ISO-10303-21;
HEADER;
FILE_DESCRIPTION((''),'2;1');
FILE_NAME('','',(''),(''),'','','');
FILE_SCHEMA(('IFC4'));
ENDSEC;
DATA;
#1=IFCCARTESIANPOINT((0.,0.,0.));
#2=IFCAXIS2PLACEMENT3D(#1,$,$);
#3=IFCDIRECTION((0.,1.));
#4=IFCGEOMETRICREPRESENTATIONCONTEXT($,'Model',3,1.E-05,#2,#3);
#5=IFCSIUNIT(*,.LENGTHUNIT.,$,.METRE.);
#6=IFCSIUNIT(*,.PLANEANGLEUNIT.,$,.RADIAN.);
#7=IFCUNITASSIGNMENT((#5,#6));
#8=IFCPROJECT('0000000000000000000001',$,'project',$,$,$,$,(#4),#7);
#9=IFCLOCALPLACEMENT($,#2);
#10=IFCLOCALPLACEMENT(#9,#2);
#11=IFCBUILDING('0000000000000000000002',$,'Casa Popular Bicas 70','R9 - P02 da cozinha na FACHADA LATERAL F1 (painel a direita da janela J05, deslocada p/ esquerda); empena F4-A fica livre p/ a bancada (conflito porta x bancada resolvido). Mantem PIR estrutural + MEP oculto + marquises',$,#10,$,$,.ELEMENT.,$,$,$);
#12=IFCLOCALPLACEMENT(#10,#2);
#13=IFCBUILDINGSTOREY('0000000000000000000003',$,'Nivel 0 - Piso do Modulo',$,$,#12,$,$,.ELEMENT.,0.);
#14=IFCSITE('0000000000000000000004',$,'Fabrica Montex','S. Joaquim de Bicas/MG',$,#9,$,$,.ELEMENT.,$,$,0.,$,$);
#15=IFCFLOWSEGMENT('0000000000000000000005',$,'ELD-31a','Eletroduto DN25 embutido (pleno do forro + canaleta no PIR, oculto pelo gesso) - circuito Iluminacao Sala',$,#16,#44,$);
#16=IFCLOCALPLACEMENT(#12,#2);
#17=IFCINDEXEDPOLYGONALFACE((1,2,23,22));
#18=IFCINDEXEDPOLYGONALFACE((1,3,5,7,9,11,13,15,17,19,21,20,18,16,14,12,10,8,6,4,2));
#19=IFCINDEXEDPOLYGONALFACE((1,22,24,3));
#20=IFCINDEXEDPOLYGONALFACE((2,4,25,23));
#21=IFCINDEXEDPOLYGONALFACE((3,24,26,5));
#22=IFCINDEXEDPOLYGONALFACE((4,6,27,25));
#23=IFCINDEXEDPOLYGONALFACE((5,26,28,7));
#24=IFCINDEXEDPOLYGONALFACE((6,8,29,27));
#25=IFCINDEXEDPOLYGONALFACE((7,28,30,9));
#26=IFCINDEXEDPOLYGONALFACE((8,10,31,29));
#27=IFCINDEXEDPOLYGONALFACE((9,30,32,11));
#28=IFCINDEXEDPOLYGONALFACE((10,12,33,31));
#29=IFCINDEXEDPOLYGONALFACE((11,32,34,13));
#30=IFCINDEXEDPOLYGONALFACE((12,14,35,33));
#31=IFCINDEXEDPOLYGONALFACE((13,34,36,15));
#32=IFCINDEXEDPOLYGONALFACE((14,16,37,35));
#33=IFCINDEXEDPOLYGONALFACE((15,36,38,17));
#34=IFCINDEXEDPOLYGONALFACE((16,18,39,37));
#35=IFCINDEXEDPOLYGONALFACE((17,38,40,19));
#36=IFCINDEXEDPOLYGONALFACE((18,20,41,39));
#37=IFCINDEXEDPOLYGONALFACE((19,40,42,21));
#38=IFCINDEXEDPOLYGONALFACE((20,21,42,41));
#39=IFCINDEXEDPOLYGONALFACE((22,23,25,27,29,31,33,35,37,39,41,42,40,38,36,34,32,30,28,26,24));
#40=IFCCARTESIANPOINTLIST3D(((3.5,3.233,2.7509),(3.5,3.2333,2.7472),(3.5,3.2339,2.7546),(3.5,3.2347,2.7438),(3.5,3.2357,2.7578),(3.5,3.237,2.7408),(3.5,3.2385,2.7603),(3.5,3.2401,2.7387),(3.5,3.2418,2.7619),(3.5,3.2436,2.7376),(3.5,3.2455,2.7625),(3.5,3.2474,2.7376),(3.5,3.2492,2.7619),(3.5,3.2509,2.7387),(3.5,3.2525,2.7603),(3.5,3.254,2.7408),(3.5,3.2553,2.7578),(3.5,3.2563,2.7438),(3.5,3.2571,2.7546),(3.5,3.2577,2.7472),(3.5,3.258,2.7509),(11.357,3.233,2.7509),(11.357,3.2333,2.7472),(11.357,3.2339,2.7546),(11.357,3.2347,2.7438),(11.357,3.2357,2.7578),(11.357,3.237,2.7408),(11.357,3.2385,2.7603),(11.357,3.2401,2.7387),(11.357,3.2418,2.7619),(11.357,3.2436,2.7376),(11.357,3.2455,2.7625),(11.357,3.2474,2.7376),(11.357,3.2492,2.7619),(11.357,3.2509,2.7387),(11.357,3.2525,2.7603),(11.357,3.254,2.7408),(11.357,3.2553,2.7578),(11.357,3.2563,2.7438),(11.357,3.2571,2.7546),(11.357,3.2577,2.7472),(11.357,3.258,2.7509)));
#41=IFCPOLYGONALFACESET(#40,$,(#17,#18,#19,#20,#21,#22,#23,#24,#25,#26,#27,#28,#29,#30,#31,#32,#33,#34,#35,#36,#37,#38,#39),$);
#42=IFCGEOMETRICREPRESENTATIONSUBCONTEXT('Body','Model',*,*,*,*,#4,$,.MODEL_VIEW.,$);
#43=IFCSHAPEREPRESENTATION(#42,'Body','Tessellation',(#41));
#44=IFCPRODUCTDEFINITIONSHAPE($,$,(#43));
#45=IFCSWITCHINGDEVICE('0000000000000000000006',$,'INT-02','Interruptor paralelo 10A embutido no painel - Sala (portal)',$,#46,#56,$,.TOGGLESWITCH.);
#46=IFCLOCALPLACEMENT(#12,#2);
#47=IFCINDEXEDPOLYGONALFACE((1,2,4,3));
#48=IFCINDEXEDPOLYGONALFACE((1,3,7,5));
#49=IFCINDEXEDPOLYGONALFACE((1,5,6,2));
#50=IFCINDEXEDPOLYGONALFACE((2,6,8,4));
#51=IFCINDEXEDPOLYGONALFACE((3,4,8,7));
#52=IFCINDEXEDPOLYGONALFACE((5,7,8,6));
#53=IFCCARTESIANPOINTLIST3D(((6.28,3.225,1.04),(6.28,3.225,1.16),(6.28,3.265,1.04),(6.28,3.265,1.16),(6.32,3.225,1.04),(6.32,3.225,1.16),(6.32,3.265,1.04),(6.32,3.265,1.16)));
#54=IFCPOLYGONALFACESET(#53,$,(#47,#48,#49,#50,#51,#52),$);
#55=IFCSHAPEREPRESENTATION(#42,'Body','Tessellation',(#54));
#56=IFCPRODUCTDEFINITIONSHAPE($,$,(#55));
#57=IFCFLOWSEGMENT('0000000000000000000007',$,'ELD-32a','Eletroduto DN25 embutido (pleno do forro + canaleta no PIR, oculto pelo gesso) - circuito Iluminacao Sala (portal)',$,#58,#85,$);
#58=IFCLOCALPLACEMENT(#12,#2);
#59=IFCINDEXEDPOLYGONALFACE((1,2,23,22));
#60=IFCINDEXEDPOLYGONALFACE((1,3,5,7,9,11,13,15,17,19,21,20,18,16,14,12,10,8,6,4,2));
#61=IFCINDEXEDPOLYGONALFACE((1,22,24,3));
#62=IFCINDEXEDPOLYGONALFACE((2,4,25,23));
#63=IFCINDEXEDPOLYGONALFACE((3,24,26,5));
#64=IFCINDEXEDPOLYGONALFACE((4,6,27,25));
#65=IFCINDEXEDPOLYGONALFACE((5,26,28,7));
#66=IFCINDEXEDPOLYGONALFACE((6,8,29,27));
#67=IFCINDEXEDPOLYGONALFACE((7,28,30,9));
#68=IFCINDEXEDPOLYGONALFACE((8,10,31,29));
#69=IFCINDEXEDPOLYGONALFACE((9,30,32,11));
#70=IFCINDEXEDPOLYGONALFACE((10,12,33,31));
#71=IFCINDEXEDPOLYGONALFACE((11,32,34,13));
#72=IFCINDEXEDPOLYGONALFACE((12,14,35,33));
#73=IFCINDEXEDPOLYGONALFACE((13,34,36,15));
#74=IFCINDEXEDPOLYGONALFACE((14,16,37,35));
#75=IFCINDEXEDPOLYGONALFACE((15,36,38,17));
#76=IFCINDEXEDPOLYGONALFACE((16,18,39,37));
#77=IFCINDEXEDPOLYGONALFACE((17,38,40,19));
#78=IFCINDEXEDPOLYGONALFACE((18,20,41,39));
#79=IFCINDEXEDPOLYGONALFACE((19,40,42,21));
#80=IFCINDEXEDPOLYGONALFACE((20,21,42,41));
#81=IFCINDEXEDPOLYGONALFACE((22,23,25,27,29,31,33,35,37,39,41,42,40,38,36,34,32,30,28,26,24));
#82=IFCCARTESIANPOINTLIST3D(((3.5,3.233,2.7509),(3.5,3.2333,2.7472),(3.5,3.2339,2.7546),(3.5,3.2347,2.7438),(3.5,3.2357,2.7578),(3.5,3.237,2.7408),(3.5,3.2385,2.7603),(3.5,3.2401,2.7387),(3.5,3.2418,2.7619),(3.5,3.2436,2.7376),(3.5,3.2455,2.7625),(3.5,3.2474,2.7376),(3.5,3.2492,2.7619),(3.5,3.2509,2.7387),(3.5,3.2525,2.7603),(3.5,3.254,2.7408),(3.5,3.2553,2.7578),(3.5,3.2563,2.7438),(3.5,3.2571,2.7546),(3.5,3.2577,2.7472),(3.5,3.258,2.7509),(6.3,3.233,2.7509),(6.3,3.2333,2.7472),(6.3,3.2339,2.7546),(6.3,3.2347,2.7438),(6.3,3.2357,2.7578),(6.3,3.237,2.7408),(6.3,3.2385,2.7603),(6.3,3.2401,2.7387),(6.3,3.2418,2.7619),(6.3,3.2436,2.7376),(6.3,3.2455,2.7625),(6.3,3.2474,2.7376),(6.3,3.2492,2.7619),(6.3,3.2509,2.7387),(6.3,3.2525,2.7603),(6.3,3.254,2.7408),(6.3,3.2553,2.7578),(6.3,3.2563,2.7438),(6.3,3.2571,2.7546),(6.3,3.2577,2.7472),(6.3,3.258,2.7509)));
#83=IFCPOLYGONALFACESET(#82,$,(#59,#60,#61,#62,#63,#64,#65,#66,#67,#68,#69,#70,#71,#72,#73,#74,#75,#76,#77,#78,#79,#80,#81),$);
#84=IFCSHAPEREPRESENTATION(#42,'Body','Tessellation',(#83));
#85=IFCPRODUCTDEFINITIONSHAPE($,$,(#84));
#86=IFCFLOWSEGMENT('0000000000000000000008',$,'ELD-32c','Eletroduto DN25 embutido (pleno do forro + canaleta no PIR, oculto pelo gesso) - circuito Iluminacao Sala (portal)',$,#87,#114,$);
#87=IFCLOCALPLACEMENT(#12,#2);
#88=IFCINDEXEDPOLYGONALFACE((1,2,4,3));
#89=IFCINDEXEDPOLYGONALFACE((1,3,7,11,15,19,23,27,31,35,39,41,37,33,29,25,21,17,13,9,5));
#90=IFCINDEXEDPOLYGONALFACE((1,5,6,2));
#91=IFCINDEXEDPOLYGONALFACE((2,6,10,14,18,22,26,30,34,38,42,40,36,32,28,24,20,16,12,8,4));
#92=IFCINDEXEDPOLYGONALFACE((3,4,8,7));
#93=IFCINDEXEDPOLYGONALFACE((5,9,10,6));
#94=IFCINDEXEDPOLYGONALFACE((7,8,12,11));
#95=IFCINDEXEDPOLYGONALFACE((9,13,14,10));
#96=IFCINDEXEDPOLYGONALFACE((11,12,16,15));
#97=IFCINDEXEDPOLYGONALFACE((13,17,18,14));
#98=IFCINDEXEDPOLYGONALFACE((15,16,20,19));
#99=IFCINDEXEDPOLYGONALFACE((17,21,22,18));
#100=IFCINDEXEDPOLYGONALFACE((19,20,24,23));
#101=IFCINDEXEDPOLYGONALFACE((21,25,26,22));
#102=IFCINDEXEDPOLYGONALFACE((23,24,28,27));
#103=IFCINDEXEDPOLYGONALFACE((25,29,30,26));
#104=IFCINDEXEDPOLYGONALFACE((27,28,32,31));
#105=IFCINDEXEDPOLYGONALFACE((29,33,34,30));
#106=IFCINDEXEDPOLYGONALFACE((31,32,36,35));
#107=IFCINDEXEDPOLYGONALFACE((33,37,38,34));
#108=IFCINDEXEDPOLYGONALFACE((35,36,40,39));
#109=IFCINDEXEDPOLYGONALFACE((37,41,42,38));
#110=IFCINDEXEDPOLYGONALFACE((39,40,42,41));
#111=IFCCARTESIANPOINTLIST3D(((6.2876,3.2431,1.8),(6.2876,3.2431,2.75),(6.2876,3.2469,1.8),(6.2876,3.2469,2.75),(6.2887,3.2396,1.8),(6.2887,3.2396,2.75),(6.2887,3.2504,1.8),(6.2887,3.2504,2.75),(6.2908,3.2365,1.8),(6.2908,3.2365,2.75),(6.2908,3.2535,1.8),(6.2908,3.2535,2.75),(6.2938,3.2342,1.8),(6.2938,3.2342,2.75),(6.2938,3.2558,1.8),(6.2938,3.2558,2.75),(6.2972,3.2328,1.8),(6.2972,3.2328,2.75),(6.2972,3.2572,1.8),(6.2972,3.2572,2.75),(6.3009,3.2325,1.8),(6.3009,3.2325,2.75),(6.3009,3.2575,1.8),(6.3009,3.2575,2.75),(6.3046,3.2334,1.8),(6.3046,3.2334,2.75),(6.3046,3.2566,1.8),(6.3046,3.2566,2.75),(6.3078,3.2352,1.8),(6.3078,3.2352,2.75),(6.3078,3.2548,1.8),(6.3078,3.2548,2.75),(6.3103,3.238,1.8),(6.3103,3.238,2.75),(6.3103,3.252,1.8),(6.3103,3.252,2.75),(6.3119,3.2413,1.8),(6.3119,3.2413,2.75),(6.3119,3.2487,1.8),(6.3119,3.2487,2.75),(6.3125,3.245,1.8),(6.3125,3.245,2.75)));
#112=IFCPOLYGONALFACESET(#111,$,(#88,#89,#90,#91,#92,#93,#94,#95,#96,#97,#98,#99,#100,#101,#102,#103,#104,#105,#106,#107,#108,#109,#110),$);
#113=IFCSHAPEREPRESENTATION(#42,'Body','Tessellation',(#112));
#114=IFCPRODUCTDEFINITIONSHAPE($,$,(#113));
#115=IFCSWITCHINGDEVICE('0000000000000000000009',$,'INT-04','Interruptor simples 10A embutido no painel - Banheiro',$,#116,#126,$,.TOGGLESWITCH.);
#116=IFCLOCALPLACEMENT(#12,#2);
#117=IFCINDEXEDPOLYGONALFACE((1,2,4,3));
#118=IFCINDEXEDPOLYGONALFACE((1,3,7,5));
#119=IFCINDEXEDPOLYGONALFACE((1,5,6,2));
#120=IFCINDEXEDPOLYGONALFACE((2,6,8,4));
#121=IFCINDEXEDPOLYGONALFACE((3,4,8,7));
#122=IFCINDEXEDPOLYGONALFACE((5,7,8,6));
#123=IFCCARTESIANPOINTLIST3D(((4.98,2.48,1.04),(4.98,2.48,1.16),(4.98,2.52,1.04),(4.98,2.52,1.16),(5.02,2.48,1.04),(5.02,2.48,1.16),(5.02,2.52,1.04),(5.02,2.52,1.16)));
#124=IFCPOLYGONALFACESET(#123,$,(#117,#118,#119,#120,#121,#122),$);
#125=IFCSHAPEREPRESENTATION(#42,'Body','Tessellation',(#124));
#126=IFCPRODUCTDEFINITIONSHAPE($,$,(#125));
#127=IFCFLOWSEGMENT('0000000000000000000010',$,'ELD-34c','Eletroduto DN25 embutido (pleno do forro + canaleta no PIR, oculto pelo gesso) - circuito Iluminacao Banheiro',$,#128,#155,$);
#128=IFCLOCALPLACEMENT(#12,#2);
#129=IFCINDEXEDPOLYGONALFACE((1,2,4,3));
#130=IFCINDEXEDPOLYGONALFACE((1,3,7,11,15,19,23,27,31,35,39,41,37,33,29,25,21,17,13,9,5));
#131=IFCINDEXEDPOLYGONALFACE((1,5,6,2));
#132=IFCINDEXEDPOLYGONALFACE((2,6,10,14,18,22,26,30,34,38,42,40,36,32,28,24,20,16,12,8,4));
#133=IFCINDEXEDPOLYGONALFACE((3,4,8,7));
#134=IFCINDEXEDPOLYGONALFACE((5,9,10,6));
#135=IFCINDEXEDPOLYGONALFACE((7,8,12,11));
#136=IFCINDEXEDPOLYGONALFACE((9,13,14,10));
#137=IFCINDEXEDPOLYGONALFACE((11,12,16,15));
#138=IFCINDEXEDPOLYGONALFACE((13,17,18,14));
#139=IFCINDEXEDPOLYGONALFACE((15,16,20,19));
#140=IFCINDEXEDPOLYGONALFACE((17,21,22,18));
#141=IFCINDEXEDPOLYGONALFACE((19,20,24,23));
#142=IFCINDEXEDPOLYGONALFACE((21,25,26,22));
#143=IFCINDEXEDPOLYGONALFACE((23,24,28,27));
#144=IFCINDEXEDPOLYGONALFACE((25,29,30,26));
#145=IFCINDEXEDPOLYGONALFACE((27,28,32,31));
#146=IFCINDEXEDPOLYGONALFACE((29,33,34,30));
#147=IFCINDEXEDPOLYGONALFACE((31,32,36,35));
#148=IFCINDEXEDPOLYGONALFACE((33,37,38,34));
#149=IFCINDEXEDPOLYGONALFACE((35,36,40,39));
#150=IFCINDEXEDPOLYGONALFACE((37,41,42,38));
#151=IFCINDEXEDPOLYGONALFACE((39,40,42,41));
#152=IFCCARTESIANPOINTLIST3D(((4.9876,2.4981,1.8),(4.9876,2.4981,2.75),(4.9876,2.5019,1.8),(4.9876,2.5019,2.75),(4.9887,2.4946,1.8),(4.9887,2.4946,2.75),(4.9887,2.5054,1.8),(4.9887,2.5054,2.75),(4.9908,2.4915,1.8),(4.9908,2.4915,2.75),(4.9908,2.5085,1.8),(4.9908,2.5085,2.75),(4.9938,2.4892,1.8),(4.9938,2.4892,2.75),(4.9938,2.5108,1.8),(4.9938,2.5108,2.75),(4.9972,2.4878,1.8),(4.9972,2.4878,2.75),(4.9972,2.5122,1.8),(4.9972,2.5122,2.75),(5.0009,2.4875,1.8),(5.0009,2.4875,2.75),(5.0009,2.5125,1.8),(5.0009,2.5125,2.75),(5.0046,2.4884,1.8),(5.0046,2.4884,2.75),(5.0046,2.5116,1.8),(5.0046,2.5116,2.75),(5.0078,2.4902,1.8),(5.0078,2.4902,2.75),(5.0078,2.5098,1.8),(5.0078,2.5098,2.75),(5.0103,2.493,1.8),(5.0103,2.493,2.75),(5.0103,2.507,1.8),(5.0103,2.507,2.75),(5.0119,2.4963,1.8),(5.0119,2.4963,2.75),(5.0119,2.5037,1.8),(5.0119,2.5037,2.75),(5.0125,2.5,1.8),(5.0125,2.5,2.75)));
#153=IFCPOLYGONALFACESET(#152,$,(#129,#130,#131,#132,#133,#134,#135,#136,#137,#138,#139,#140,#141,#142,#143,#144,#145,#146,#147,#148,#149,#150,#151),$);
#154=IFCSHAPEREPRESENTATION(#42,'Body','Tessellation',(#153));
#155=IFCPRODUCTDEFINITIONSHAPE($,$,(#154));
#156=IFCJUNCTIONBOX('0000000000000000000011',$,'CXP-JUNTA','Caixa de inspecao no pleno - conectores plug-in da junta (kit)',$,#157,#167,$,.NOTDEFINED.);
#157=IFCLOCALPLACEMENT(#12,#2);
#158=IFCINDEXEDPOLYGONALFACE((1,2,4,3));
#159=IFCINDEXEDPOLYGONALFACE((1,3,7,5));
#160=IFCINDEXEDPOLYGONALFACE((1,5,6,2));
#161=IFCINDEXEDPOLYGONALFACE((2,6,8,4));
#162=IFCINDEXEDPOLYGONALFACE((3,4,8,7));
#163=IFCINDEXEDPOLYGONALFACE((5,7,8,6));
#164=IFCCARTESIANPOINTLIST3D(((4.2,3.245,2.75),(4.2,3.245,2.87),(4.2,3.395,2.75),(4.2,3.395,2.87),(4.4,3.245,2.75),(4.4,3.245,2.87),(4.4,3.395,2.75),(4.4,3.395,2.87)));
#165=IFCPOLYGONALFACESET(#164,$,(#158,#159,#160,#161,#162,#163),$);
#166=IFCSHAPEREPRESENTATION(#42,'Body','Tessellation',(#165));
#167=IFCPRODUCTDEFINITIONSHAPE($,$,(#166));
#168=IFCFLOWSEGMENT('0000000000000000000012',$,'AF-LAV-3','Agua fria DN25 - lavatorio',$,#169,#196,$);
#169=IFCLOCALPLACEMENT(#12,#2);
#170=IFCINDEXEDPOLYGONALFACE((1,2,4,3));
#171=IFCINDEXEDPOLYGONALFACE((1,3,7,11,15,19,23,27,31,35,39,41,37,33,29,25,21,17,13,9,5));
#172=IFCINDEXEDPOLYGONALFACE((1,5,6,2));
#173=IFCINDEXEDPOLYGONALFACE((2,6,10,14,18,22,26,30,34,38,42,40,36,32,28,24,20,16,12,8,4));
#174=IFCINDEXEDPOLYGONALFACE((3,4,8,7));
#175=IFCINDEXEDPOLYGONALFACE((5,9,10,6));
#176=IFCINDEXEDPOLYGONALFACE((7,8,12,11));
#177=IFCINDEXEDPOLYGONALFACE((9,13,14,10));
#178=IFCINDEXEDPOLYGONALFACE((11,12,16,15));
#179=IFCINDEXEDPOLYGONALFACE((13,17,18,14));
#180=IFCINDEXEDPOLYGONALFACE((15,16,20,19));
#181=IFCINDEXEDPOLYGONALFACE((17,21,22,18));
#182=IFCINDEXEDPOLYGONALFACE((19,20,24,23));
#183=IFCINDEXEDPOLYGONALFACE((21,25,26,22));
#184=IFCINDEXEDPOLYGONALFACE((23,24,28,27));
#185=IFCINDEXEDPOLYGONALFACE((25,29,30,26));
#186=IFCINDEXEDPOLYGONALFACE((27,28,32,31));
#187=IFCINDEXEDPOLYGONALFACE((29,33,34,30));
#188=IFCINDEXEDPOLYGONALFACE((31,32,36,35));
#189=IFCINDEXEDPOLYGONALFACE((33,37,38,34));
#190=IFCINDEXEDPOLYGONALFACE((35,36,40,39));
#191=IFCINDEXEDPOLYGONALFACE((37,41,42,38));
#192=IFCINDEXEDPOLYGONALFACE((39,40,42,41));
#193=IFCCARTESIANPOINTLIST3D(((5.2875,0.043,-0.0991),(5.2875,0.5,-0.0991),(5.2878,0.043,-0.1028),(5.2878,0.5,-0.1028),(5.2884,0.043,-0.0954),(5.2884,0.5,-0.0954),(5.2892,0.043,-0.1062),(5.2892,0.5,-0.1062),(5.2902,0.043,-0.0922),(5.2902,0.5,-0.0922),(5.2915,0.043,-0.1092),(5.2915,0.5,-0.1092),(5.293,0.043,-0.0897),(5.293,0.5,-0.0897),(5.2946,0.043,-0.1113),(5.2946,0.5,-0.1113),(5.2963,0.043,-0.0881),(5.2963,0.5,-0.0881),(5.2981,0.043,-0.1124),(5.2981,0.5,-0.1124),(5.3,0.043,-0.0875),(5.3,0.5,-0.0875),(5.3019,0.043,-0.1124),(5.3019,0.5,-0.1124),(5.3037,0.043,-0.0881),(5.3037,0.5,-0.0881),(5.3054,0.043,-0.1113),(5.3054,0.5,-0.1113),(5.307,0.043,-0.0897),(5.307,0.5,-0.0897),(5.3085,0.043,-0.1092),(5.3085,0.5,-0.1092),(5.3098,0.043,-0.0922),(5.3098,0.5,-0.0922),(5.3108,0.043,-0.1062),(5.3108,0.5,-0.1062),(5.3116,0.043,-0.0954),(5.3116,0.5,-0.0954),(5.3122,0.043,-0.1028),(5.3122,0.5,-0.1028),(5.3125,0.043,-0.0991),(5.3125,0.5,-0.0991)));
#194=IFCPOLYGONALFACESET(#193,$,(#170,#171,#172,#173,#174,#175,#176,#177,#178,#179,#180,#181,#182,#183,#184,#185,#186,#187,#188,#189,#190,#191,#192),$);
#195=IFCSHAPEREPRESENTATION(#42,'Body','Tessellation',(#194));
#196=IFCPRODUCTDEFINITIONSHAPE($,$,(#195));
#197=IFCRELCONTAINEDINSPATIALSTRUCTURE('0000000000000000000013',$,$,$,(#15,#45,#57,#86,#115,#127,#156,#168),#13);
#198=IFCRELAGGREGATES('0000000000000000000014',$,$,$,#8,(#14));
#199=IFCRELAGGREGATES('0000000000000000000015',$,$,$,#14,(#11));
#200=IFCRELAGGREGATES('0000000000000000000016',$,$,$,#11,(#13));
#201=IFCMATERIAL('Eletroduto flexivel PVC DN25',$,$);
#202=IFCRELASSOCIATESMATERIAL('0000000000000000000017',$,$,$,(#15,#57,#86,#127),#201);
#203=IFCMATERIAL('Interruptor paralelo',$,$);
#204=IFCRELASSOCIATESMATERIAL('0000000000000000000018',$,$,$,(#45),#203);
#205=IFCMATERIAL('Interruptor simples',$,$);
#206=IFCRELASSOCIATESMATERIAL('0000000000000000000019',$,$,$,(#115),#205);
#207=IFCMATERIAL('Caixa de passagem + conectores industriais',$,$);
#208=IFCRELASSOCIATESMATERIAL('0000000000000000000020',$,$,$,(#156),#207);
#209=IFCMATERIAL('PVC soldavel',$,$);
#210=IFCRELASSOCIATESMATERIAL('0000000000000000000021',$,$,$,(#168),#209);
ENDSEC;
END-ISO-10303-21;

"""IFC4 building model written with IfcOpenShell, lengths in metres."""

from ifc_helpers import new_model, si_unit, direction, frame, frame_2d, origin, origin_2d, place, context, subcontext, project, spatial, rectangle, circle, extrude, material, element, save


model = new_model("IFC4")

# Units and contexts
model_context = context("Model", 3, precision=1e-05, world=origin(), true_north=direction((0.0, 1.0)))
body_context = subcontext(model_context, "Body", "Model", "MODEL_VIEW")
ifc_project = project(units=[si_unit("LENGTHUNIT", "METRE"), si_unit("PLANEANGLEUNIT", "RADIAN")], contexts=[model_context])

# Site, building, storey
site_placement = place(None, origin())
site = spatial("IfcSite", under=ifc_project, at=site_placement, Name="Fabrica Montex", Description="S. Joaquim de Bicas/MG", CompositionType="ELEMENT", RefElevation=0.0)
building_placement = place(site_placement, origin())
building = spatial("IfcBuilding", under=site, at=building_placement, Name="Casa Popular Bicas 70", Description="R9 - P02 da cozinha na FACHADA LATERAL F1 (painel a direita da janela J05, deslocada p/ esquerda); empena F4-A fica livre p/ a bancada (conflito porta x bancada resolvido). Mantem PIR estrutural + MEP oculto + marquises", CompositionType="ELEMENT")
storey_placement = place(building_placement, origin())
storey = spatial("IfcBuildingStorey", under=building, at=storey_placement, Name="Nivel 0 - Piso do Modulo", CompositionType="ELEMENT", Elevation=0.0)

# Shared definitions
ifc_material_1 = material(Name="Eletroduto flexivel PVC DN25")

# Flow segment
flow_segment_1_placement = place(storey_placement, frame((3.5, 3.2455, 2.75), z_axis=(1.0, 0.0, 0.0), x_axis=(0.0, 0.0, 1.0)))
element("IfcFlowSegment", 1, at=flow_segment_1_placement, inside=storey, material=ifc_material_1, Name="ELD-31a", Description="Eletroduto DN25 embutido (pleno do forro + canaleta no PIR, oculto pelo gesso) - circuito Iluminacao Sala", context=body_context, shape_type="SweptSolid", body=[
    extrude(circle(Radius=0.0125, at=origin_2d()), origin(), (0.0, 0.0, 1.0), 7.857),
])

# Switching device
ifc_material_2 = material(Name="Interruptor paralelo")
switching_device_1_placement = place(storey_placement, frame((6.28, 3.225, 1.04)))
element("IfcSwitchingDevice", 2, at=switching_device_1_placement, inside=storey, material=ifc_material_2, Name="INT-02", Description="Interruptor paralelo 10A embutido no painel - Sala (portal)", PredefinedType="TOGGLESWITCH", context=body_context, shape_type="SweptSolid", body=[
    extrude(rectangle(XDim=0.04, YDim=0.04, at=frame_2d((0.02, 0.02))), origin(), (0.0, 0.0, 1.0), 0.12),
])

# Flow segments
flow_segment_2_placement = place(storey_placement, frame((3.5, 3.2455, 2.75), z_axis=(1.0, 0.0, 0.0), x_axis=(0.0, 0.0, 1.0)))
element("IfcFlowSegment", 3, at=flow_segment_2_placement, inside=storey, material=ifc_material_1, Name="ELD-32a", Description="Eletroduto DN25 embutido (pleno do forro + canaleta no PIR, oculto pelo gesso) - circuito Iluminacao Sala (portal)", context=body_context, shape_type="SweptSolid", body=[
    extrude(circle(Radius=0.0125, at=origin_2d()), origin(), (0.0, 0.0, 1.0), 2.8),
])
flow_segment_3_placement = place(storey_placement, frame((6.3, 3.245, 2.75), z_axis=(0.0, 0.0, -1.0), x_axis=(1.0, 0.0, 0.0)))
element("IfcFlowSegment", 4, at=flow_segment_3_placement, inside=storey, material=ifc_material_1, Name="ELD-32c", Description="Eletroduto DN25 embutido (pleno do forro + canaleta no PIR, oculto pelo gesso) - circuito Iluminacao Sala (portal)", context=body_context, shape_type="SweptSolid", body=[
    extrude(circle(Radius=0.0125, at=origin_2d()), origin(), (0.0, 0.0, 1.0), 0.95),
])

# Switching device
ifc_material_3 = material(Name="Interruptor simples")
switching_device_2_placement = place(storey_placement, frame((4.98, 2.48, 1.04)))
element("IfcSwitchingDevice", 5, at=switching_device_2_placement, inside=storey, material=ifc_material_3, Name="INT-04", Description="Interruptor simples 10A embutido no painel - Banheiro", PredefinedType="TOGGLESWITCH", context=body_context, shape_type="SweptSolid", body=[
    extrude(rectangle(XDim=0.04, YDim=0.04, at=frame_2d((0.02, 0.02))), origin(), (0.0, 0.0, 1.0), 0.12),
])

# Flow segment
flow_segment_4_placement = place(storey_placement, frame((5.0, 2.5, 2.75), z_axis=(0.0, 0.0, -1.0), x_axis=(1.0, 0.0, 0.0)))
element("IfcFlowSegment", 6, at=flow_segment_4_placement, inside=storey, material=ifc_material_1, Name="ELD-34c", Description="Eletroduto DN25 embutido (pleno do forro + canaleta no PIR, oculto pelo gesso) - circuito Iluminacao Banheiro", context=body_context, shape_type="SweptSolid", body=[
    extrude(circle(Radius=0.0125, at=origin_2d()), origin(), (0.0, 0.0, 1.0), 0.95),
])

# Junction box
ifc_material_4 = material(Name="Caixa de passagem + conectores industriais")
junction_box_placement = place(storey_placement, frame((4.2, 3.245, 2.75)))
element("IfcJunctionBox", 7, at=junction_box_placement, inside=storey, material=ifc_material_4, Name="CXP-JUNTA", Description="Caixa de inspecao no pleno - conectores plug-in da junta (kit)", PredefinedType="NOTDEFINED", context=body_context, shape_type="SweptSolid", body=[
    extrude(rectangle(XDim=0.2, YDim=0.15, at=frame_2d((0.1, 0.075))), origin(), (0.0, 0.0, 1.0), 0.12),
])

# Flow segment
ifc_material_5 = material(Name="PVC soldavel")
flow_segment_5_placement = place(storey_placement, frame((5.3, 0.5, -0.1), z_axis=(0.0, -1.0, 0.0), x_axis=(0.0, 0.0, 1.0)))
element("IfcFlowSegment", 8, at=flow_segment_5_placement, inside=storey, material=ifc_material_5, Name="AF-LAV-3", Description="Agua fria DN25 - lavatorio", context=body_context, shape_type="SweptSolid", body=[
    extrude(circle(Radius=0.0125, at=origin_2d()), origin(), (0.0, 0.0, 1.0), 0.457),
])

save(model, "model.ifc")
